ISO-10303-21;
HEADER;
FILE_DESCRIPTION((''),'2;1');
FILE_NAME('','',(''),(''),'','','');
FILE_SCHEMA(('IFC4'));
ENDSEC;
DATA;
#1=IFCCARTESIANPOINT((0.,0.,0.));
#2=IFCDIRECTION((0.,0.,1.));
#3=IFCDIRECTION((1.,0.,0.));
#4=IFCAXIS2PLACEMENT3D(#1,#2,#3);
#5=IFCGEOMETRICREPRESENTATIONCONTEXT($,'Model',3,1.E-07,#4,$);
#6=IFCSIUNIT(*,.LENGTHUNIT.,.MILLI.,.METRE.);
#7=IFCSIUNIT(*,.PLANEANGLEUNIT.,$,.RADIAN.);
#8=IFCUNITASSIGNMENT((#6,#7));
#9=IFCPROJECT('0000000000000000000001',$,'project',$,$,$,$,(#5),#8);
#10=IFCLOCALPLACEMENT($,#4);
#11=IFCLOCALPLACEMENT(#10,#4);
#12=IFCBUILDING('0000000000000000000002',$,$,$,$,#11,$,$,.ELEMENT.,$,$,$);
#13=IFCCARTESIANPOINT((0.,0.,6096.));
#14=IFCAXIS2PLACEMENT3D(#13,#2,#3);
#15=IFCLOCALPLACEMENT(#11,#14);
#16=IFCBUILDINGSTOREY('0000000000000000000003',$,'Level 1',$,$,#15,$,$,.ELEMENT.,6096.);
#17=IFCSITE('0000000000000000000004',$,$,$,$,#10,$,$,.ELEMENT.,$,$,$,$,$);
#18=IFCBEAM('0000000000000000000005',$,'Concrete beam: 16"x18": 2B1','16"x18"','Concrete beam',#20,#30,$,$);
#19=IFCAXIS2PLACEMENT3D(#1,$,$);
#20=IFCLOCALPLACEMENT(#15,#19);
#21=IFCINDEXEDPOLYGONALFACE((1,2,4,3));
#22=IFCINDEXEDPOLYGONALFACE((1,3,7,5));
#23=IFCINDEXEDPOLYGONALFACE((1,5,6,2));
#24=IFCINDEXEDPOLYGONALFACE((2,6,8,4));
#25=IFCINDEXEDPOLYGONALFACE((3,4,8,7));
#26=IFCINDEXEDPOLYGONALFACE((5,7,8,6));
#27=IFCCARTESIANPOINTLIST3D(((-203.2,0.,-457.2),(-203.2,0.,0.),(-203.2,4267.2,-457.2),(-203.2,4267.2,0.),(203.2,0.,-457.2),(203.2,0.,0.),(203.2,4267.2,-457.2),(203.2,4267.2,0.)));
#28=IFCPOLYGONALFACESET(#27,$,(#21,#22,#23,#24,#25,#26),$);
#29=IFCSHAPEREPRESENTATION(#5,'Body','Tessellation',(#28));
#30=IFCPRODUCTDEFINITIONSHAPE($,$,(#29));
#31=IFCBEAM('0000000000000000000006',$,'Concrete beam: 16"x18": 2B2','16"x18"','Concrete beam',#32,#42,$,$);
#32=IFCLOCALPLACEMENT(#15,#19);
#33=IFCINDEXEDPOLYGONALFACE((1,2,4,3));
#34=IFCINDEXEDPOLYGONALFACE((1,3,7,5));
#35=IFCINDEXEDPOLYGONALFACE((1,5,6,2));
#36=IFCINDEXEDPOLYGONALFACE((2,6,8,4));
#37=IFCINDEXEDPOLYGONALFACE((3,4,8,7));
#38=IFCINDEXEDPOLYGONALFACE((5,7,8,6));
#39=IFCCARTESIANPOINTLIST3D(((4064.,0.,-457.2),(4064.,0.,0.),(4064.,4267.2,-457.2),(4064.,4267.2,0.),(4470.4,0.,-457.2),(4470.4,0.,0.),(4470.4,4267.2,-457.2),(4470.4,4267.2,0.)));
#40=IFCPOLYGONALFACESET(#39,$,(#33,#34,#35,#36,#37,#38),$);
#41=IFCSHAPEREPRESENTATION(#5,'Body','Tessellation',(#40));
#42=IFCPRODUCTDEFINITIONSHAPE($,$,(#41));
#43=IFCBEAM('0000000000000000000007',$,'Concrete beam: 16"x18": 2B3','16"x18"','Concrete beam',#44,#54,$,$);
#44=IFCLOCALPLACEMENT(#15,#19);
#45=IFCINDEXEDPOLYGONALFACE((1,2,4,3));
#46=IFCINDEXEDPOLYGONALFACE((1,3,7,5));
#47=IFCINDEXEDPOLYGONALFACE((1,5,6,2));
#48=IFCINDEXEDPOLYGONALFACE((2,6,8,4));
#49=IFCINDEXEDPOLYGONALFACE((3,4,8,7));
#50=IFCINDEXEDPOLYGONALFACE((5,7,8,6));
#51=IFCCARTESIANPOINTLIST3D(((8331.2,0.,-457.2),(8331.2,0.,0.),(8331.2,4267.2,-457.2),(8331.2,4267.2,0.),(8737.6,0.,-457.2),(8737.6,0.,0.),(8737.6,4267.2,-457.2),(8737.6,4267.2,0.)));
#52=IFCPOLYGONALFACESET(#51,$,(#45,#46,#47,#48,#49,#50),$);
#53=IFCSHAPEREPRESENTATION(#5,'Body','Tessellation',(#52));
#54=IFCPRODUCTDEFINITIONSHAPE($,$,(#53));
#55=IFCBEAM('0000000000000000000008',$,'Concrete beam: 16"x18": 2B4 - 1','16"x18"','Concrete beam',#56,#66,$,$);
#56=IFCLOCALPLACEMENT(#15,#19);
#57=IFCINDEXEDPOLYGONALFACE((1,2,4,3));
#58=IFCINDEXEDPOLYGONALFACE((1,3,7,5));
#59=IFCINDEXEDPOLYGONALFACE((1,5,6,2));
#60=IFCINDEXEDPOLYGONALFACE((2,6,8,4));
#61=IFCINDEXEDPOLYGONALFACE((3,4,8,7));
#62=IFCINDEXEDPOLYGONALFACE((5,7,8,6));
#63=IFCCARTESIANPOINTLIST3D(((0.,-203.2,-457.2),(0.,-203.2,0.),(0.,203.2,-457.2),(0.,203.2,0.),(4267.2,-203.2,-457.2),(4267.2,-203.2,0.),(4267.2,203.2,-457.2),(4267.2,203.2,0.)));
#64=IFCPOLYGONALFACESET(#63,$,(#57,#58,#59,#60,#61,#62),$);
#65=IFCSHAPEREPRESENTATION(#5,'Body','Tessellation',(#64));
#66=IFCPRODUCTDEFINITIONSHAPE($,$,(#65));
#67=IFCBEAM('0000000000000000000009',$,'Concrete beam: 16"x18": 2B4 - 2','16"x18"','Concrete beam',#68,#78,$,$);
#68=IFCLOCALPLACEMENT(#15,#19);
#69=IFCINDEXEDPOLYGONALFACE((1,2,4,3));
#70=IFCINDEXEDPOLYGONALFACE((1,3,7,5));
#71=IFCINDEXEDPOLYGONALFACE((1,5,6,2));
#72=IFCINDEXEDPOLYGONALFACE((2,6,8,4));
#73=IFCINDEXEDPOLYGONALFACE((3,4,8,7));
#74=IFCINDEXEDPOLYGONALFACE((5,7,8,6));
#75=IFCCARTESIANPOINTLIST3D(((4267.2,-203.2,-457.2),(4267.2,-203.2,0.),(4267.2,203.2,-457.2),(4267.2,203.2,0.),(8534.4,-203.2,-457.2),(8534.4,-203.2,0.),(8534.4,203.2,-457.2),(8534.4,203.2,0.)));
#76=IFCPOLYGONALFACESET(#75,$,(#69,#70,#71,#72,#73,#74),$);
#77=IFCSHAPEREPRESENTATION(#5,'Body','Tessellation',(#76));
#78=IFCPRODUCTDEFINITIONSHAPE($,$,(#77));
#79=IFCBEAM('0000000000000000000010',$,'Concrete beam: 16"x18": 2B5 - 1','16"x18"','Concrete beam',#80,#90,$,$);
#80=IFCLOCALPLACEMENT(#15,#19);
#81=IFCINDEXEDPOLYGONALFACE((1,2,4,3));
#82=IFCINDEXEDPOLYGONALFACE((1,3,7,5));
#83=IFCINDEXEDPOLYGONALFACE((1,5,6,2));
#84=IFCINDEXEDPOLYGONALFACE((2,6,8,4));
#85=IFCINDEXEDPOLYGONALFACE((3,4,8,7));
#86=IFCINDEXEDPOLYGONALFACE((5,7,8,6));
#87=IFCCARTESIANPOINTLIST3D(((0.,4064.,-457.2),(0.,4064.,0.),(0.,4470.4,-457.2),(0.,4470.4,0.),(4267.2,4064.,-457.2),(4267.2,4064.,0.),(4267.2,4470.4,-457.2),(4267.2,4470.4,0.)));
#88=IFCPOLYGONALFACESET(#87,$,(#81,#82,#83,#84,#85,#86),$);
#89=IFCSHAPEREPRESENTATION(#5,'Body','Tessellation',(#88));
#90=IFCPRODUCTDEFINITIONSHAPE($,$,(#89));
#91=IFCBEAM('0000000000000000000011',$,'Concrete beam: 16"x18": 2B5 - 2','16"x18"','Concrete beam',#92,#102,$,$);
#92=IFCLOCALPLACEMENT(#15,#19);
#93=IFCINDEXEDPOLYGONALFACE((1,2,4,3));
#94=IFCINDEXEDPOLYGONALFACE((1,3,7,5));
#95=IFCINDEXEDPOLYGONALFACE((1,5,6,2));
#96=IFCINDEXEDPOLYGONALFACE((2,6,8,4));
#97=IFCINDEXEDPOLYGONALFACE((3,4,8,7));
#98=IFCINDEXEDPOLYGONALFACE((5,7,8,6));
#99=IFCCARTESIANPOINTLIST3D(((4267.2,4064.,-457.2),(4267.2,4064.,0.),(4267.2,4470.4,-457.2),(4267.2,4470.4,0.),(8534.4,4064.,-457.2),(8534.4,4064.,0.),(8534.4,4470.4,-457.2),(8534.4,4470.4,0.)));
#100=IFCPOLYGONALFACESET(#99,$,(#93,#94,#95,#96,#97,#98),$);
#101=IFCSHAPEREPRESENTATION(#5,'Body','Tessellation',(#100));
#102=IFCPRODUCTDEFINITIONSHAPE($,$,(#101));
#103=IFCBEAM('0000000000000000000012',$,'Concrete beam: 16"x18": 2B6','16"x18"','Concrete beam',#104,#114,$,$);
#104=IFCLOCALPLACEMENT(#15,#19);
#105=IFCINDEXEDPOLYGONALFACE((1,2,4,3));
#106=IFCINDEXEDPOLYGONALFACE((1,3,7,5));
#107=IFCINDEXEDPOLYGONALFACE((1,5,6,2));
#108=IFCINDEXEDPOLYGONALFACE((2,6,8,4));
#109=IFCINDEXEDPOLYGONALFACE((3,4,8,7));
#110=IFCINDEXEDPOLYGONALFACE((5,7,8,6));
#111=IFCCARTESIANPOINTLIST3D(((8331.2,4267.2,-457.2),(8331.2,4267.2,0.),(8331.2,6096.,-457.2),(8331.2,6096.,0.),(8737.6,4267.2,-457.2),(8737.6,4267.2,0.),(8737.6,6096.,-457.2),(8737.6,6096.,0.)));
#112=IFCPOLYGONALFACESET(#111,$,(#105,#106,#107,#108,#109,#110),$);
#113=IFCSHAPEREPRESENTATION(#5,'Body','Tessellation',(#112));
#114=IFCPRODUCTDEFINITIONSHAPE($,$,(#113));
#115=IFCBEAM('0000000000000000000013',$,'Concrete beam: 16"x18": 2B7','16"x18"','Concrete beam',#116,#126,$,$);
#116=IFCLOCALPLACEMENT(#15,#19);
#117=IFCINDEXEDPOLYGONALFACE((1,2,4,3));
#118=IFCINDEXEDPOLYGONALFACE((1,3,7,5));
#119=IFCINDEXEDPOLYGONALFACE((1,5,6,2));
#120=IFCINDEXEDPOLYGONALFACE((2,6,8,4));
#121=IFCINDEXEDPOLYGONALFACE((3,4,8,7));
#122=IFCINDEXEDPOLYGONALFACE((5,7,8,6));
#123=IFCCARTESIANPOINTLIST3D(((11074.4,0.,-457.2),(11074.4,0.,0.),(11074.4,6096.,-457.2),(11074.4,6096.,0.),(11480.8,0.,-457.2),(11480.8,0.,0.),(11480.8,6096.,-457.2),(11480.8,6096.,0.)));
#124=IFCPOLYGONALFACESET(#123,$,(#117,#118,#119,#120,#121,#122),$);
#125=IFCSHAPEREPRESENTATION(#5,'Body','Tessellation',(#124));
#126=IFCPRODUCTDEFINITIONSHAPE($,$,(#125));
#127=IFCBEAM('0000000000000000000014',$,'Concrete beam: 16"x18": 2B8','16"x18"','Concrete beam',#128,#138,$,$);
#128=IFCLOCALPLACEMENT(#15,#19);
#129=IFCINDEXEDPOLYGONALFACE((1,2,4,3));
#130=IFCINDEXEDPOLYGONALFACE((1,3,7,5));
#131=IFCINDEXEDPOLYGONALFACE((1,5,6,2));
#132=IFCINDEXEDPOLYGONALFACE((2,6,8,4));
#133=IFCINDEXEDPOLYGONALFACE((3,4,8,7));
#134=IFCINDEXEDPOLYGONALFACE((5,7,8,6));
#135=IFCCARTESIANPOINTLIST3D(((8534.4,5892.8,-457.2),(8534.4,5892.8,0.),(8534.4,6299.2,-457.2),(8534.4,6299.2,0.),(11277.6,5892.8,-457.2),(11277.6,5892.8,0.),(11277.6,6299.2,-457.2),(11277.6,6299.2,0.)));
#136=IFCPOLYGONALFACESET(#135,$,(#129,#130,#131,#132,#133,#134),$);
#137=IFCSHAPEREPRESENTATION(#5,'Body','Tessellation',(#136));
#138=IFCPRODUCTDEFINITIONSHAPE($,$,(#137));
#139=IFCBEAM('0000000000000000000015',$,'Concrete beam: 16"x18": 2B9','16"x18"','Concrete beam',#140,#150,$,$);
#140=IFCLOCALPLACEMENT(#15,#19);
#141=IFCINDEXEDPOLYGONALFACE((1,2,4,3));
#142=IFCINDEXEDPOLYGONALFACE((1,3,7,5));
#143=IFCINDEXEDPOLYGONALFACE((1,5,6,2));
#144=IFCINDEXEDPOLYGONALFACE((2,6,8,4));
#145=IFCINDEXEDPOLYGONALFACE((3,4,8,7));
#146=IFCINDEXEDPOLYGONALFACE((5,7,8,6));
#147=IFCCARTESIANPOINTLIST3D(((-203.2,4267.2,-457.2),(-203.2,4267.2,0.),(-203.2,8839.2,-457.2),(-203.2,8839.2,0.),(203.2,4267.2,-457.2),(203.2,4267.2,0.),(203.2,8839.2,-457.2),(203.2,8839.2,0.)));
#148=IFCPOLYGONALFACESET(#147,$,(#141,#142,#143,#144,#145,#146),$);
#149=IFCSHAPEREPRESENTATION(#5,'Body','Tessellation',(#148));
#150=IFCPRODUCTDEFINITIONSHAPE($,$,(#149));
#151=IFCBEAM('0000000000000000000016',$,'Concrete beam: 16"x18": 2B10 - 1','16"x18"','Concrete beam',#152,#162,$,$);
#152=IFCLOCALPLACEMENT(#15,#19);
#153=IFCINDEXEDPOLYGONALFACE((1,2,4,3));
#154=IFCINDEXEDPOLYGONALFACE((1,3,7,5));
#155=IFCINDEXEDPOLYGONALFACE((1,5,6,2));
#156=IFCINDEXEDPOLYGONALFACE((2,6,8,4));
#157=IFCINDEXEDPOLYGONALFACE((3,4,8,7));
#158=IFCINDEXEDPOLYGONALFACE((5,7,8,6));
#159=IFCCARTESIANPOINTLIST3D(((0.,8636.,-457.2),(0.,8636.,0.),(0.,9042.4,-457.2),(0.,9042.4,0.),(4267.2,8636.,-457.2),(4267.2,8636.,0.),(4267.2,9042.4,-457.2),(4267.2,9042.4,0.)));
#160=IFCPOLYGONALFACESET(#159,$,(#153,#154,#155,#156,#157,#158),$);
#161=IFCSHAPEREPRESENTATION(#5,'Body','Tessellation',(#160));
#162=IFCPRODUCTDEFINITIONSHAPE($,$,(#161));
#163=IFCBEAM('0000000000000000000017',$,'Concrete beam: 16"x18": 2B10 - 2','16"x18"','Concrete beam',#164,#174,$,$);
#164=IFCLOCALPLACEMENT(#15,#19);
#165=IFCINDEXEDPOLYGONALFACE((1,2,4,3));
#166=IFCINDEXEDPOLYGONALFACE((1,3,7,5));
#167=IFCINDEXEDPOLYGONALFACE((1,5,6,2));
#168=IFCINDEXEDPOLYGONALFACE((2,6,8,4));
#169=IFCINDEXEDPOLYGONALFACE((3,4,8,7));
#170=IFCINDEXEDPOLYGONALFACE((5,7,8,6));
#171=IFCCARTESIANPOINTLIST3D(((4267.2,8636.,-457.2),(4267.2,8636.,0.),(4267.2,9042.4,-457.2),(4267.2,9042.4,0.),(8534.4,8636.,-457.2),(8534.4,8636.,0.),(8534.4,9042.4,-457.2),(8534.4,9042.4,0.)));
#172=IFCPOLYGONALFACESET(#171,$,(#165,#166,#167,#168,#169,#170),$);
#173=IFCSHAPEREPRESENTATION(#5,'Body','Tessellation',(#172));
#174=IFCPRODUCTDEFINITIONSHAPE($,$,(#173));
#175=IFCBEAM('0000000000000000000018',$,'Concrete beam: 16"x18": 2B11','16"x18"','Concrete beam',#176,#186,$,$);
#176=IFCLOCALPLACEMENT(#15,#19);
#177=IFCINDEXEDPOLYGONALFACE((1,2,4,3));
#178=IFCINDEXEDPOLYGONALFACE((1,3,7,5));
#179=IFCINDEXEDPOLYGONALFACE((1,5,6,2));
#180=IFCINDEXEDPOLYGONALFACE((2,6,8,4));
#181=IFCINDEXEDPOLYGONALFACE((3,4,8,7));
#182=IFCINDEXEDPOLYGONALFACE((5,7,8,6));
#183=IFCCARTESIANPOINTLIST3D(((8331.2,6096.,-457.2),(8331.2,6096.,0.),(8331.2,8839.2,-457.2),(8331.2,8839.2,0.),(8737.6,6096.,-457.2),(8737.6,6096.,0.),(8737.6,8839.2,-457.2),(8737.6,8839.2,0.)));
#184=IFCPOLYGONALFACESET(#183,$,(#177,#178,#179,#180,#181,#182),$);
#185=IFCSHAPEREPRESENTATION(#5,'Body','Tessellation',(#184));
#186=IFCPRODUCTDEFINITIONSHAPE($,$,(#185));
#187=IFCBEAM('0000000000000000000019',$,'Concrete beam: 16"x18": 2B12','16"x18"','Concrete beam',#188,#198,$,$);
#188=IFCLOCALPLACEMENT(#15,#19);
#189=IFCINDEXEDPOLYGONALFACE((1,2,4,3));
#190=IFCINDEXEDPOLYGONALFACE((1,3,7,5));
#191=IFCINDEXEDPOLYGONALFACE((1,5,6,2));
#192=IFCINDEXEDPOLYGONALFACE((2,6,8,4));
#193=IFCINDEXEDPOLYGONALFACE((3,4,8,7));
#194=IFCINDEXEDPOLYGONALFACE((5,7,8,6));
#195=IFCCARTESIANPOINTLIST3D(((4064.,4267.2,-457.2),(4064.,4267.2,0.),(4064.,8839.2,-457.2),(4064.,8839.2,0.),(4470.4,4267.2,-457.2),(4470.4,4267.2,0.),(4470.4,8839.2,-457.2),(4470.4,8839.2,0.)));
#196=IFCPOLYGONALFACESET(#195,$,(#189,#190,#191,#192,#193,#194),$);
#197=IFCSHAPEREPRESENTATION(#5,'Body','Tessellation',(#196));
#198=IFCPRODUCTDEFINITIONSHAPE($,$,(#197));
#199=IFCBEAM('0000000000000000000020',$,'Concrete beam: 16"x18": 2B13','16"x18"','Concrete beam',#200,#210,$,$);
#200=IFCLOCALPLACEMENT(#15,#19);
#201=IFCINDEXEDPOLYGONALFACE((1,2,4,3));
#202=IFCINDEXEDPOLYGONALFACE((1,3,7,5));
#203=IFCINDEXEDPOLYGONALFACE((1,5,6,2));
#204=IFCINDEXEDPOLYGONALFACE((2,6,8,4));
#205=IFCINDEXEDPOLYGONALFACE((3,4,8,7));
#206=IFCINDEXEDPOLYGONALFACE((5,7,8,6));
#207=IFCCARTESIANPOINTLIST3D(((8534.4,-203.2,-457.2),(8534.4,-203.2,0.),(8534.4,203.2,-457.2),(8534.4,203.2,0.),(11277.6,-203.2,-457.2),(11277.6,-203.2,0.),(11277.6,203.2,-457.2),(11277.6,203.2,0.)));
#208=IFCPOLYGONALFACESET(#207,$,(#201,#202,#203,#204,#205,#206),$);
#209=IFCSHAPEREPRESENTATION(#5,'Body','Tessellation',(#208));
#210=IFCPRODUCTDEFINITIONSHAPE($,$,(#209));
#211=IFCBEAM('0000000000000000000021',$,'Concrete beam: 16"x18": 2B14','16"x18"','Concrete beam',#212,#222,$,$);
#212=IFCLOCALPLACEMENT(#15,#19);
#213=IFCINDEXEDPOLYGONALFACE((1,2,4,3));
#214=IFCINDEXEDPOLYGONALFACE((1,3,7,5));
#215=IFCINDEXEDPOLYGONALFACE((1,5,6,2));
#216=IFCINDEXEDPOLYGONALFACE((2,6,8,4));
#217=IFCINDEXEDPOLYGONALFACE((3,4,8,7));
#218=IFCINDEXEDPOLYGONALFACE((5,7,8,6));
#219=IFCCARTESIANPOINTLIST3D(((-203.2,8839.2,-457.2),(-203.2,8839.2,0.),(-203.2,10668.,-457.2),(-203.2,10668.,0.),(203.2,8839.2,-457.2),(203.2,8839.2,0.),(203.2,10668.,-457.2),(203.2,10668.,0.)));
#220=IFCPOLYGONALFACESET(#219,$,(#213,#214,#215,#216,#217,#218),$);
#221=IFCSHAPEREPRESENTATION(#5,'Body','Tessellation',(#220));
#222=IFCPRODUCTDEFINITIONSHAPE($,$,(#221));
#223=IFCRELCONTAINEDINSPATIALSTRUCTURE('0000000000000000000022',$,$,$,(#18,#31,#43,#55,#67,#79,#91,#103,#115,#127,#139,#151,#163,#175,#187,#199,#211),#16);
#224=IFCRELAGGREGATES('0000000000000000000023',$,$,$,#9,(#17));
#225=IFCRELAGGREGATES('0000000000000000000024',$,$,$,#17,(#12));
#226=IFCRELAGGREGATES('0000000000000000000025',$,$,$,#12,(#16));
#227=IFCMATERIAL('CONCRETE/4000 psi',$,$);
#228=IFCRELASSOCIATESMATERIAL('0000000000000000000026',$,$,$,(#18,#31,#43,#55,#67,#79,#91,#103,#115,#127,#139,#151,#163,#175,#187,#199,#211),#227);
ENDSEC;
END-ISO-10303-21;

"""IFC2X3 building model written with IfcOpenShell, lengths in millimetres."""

from ifc_helpers import new_model, si_unit, frame, origin_with_axes, origin_2d_with_axis, place, context, project, spatial, rectangle, extrude, material, element, save


model = new_model("IFC2X3")

# Units and contexts
model_context = context("Model", 3, precision=1e-07, world=origin_with_axes())
ifc_project = project(units=[si_unit("LENGTHUNIT", "METRE", prefix="MILLI"), si_unit("PLANEANGLEUNIT", "RADIAN")], contexts=[model_context])

# Site, building, storey
site_placement = place(None, origin_with_axes())
site = spatial("IfcSite", under=ifc_project, at=site_placement, CompositionType="ELEMENT")
building_placement = place(site_placement, origin_with_axes())
building = spatial("IfcBuilding", under=site, at=building_placement, CompositionType="ELEMENT")
storey_placement = place(building_placement, frame((0.0, 0.0, 6096.0), z_axis=(0.0, 0.0, 1.0), x_axis=(1.0, 0.0, 0.0)))
storey = spatial("IfcBuildingStorey", under=building, at=storey_placement, Name="Level 1", CompositionType="ELEMENT", Elevation=6096.0)

# Beams
ifc_material = material(Name="CONCRETE/4000 psi")
for number, where, z_axis, x_axis, name in (
    (1, (0.0, 0.0, 6096.0), (0.0, 0.0, 1.0), (0.0, 1.0, 0.0), "Concrete beam: 16\"x18\": 2B1"),
    (2, (4267.2, 0.0, 6096.0), (0.0, 0.0, 1.0), (0.0, 1.0, 0.0), "Concrete beam: 16\"x18\": 2B2"),
    (3, (8534.4, 0.0, 6096.0), (0.0, 0.0, 1.0), (0.0, 1.0, 0.0), "Concrete beam: 16\"x18\": 2B3"),
    (4, (0.0, 0.0, 6096.0), (0.0, 0.0, 1.0), (1.0, 0.0, 0.0), "Concrete beam: 16\"x18\": 2B4 - 1"),
    (5, (4267.2, 0.0, 6096.0), (0.0, 0.0, 1.0), (1.0, 0.0, 0.0), "Concrete beam: 16\"x18\": 2B4 - 2"),
    (6, (0.0, 4267.2, 6096.0), (0.0, 0.0, 1.0), (1.0, 0.0, 0.0), "Concrete beam: 16\"x18\": 2B5 - 1"),
    (7, (4267.2, 4267.2, 6096.0), (0.0, 0.0, 1.0), (1.0, 0.0, 0.0), "Concrete beam: 16\"x18\": 2B5 - 2"),
):
    element("IfcBeam", number, at=place(building_placement, frame(where, z_axis=z_axis, x_axis=x_axis)), inside=storey, material=ifc_material, Name=name, Description="16\"x18\"", ObjectType="Concrete beam", context=model_context, shape_type="SweptSolid", body=[
        extrude(rectangle(XDim=406.4, YDim=457.2, at=origin_2d_with_axis()), frame((4267.2, 0.0, -228.6), z_axis=(-1.0, 0.0, 0.0), x_axis=(0.0, -1.0, 0.0)), (0.0, 0.0, 1.0), 4267.2),
    ])
beam_1_placement = place(building_placement, frame((8534.4, 4267.2, 6096.0), z_axis=(0.0, 0.0, 1.0), x_axis=(0.0, 1.0, 0.0)))
element("IfcBeam", 8, at=beam_1_placement, inside=storey, material=ifc_material, Name="Concrete beam: 16\"x18\": 2B6", Description="16\"x18\"", ObjectType="Concrete beam", context=model_context, shape_type="SweptSolid", body=[
    extrude(rectangle(XDim=406.4, YDim=457.2, at=origin_2d_with_axis()), frame((1828.8, 0.0, -228.6), z_axis=(-1.0, 0.0, 0.0), x_axis=(0.0, -1.0, 0.0)), (0.0, 0.0, 1.0), 1828.8),
])
beam_2_placement = place(building_placement, frame((11277.6, 0.0, 6096.0), z_axis=(0.0, 0.0, 1.0), x_axis=(0.0, 1.0, 0.0)))
element("IfcBeam", 9, at=beam_2_placement, inside=storey, material=ifc_material, Name="Concrete beam: 16\"x18\": 2B7", Description="16\"x18\"", ObjectType="Concrete beam", context=model_context, shape_type="SweptSolid", body=[
    extrude(rectangle(XDim=406.4, YDim=457.2, at=origin_2d_with_axis()), frame((6096.0, 0.0, -228.6), z_axis=(-1.0, 0.0, 0.0), x_axis=(0.0, -1.0, 0.0)), (0.0, 0.0, 1.0), 6096.0),
])
beam_3_placement = place(building_placement, frame((8534.4, 6096.0, 6096.0), z_axis=(0.0, 0.0, 1.0), x_axis=(1.0, 0.0, 0.0)))
element("IfcBeam", 10, at=beam_3_placement, inside=storey, material=ifc_material, Name="Concrete beam: 16\"x18\": 2B8", Description="16\"x18\"", ObjectType="Concrete beam", context=model_context, shape_type="SweptSolid", body=[
    extrude(rectangle(XDim=406.4, YDim=457.2, at=origin_2d_with_axis()), frame((2743.2, 0.0, -228.6), z_axis=(-1.0, 0.0, 0.0), x_axis=(0.0, -1.0, 0.0)), (0.0, 0.0, 1.0), 2743.2),
])
beam_4_placement = place(building_placement, frame((0.0, 4267.2, 6096.0), z_axis=(0.0, 0.0, 1.0), x_axis=(0.0, 1.0, 0.0)))
element("IfcBeam", 11, at=beam_4_placement, inside=storey, material=ifc_material, Name="Concrete beam: 16\"x18\": 2B9", Description="16\"x18\"", ObjectType="Concrete beam", context=model_context, shape_type="SweptSolid", body=[
    extrude(rectangle(XDim=406.4, YDim=457.2, at=origin_2d_with_axis()), frame((4572.0, 0.0, -228.6), z_axis=(-1.0, 0.0, 0.0), x_axis=(0.0, -1.0, 0.0)), (0.0, 0.0, 1.0), 4572.0),
])
for number, where, z_axis, x_axis, name in (
    (12, (0.0, 8839.2, 6096.0), (0.0, 0.0, 1.0), (1.0, 0.0, 0.0), "Concrete beam: 16\"x18\": 2B10 - 1"),
    (13, (4267.2, 8839.2, 6096.0), (0.0, 0.0, 1.0), (1.0, 0.0, 0.0), "Concrete beam: 16\"x18\": 2B10 - 2"),
):
    element("IfcBeam", number, at=place(building_placement, frame(where, z_axis=z_axis, x_axis=x_axis)), inside=storey, material=ifc_material, Name=name, Description="16\"x18\"", ObjectType="Concrete beam", context=model_context, shape_type="SweptSolid", body=[
        extrude(rectangle(XDim=406.4, YDim=457.2, at=origin_2d_with_axis()), frame((4267.2, 0.0, -228.6), z_axis=(-1.0, 0.0, 0.0), x_axis=(0.0, -1.0, 0.0)), (0.0, 0.0, 1.0), 4267.2),
    ])
beam_5_placement = place(building_placement, frame((8534.4, 6096.0, 6096.0), z_axis=(0.0, 0.0, 1.0), x_axis=(0.0, 1.0, 0.0)))
element("IfcBeam", 14, at=beam_5_placement, inside=storey, material=ifc_material, Name="Concrete beam: 16\"x18\": 2B11", Description="16\"x18\"", ObjectType="Concrete beam", context=model_context, shape_type="SweptSolid", body=[
    extrude(rectangle(XDim=406.4, YDim=457.2, at=origin_2d_with_axis()), frame((2743.2, 0.0, -228.6), z_axis=(-1.0, 0.0, 0.0), x_axis=(0.0, -1.0, 0.0)), (0.0, 0.0, 1.0), 2743.2),
])
beam_6_placement = place(building_placement, frame((4267.2, 4267.2, 6096.0), z_axis=(0.0, 0.0, 1.0), x_axis=(0.0, 1.0, 0.0)))
element("IfcBeam", 15, at=beam_6_placement, inside=storey, material=ifc_material, Name="Concrete beam: 16\"x18\": 2B12", Description="16\"x18\"", ObjectType="Concrete beam", context=model_context, shape_type="SweptSolid", body=[
    extrude(rectangle(XDim=406.4, YDim=457.2, at=origin_2d_with_axis()), frame((4572.0, 0.0, -228.6), z_axis=(-1.0, 0.0, 0.0), x_axis=(0.0, -1.0, 0.0)), (0.0, 0.0, 1.0), 4572.0),
])
beam_7_placement = place(building_placement, frame((8534.4, 0.0, 6096.0), z_axis=(0.0, 0.0, 1.0), x_axis=(1.0, 0.0, 0.0)))
element("IfcBeam", 16, at=beam_7_placement, inside=storey, material=ifc_material, Name="Concrete beam: 16\"x18\": 2B13", Description="16\"x18\"", ObjectType="Concrete beam", context=model_context, shape_type="SweptSolid", body=[
    extrude(rectangle(XDim=406.4, YDim=457.2, at=origin_2d_with_axis()), frame((2743.2, 0.0, -228.6), z_axis=(-1.0, 0.0, 0.0), x_axis=(0.0, -1.0, 0.0)), (0.0, 0.0, 1.0), 2743.2),
])
beam_8_placement = place(building_placement, frame((0.0, 10668.0, 6096.0), z_axis=(0.0, 0.0, 1.0), x_axis=(0.0, -1.0, 0.0)))
element("IfcBeam", 17, at=beam_8_placement, inside=storey, material=ifc_material, Name="Concrete beam: 16\"x18\": 2B14", Description="16\"x18\"", ObjectType="Concrete beam", context=model_context, shape_type="SweptSolid", body=[
    extrude(rectangle(XDim=406.4, YDim=457.2, at=origin_2d_with_axis()), frame((1828.8, 0.0, -228.6), z_axis=(-1.0, 0.0, 0.0), x_axis=(0.0, -1.0, 0.0)), (0.0, 0.0, 1.0), 1828.8),
])

save(model, "model.ifc")
